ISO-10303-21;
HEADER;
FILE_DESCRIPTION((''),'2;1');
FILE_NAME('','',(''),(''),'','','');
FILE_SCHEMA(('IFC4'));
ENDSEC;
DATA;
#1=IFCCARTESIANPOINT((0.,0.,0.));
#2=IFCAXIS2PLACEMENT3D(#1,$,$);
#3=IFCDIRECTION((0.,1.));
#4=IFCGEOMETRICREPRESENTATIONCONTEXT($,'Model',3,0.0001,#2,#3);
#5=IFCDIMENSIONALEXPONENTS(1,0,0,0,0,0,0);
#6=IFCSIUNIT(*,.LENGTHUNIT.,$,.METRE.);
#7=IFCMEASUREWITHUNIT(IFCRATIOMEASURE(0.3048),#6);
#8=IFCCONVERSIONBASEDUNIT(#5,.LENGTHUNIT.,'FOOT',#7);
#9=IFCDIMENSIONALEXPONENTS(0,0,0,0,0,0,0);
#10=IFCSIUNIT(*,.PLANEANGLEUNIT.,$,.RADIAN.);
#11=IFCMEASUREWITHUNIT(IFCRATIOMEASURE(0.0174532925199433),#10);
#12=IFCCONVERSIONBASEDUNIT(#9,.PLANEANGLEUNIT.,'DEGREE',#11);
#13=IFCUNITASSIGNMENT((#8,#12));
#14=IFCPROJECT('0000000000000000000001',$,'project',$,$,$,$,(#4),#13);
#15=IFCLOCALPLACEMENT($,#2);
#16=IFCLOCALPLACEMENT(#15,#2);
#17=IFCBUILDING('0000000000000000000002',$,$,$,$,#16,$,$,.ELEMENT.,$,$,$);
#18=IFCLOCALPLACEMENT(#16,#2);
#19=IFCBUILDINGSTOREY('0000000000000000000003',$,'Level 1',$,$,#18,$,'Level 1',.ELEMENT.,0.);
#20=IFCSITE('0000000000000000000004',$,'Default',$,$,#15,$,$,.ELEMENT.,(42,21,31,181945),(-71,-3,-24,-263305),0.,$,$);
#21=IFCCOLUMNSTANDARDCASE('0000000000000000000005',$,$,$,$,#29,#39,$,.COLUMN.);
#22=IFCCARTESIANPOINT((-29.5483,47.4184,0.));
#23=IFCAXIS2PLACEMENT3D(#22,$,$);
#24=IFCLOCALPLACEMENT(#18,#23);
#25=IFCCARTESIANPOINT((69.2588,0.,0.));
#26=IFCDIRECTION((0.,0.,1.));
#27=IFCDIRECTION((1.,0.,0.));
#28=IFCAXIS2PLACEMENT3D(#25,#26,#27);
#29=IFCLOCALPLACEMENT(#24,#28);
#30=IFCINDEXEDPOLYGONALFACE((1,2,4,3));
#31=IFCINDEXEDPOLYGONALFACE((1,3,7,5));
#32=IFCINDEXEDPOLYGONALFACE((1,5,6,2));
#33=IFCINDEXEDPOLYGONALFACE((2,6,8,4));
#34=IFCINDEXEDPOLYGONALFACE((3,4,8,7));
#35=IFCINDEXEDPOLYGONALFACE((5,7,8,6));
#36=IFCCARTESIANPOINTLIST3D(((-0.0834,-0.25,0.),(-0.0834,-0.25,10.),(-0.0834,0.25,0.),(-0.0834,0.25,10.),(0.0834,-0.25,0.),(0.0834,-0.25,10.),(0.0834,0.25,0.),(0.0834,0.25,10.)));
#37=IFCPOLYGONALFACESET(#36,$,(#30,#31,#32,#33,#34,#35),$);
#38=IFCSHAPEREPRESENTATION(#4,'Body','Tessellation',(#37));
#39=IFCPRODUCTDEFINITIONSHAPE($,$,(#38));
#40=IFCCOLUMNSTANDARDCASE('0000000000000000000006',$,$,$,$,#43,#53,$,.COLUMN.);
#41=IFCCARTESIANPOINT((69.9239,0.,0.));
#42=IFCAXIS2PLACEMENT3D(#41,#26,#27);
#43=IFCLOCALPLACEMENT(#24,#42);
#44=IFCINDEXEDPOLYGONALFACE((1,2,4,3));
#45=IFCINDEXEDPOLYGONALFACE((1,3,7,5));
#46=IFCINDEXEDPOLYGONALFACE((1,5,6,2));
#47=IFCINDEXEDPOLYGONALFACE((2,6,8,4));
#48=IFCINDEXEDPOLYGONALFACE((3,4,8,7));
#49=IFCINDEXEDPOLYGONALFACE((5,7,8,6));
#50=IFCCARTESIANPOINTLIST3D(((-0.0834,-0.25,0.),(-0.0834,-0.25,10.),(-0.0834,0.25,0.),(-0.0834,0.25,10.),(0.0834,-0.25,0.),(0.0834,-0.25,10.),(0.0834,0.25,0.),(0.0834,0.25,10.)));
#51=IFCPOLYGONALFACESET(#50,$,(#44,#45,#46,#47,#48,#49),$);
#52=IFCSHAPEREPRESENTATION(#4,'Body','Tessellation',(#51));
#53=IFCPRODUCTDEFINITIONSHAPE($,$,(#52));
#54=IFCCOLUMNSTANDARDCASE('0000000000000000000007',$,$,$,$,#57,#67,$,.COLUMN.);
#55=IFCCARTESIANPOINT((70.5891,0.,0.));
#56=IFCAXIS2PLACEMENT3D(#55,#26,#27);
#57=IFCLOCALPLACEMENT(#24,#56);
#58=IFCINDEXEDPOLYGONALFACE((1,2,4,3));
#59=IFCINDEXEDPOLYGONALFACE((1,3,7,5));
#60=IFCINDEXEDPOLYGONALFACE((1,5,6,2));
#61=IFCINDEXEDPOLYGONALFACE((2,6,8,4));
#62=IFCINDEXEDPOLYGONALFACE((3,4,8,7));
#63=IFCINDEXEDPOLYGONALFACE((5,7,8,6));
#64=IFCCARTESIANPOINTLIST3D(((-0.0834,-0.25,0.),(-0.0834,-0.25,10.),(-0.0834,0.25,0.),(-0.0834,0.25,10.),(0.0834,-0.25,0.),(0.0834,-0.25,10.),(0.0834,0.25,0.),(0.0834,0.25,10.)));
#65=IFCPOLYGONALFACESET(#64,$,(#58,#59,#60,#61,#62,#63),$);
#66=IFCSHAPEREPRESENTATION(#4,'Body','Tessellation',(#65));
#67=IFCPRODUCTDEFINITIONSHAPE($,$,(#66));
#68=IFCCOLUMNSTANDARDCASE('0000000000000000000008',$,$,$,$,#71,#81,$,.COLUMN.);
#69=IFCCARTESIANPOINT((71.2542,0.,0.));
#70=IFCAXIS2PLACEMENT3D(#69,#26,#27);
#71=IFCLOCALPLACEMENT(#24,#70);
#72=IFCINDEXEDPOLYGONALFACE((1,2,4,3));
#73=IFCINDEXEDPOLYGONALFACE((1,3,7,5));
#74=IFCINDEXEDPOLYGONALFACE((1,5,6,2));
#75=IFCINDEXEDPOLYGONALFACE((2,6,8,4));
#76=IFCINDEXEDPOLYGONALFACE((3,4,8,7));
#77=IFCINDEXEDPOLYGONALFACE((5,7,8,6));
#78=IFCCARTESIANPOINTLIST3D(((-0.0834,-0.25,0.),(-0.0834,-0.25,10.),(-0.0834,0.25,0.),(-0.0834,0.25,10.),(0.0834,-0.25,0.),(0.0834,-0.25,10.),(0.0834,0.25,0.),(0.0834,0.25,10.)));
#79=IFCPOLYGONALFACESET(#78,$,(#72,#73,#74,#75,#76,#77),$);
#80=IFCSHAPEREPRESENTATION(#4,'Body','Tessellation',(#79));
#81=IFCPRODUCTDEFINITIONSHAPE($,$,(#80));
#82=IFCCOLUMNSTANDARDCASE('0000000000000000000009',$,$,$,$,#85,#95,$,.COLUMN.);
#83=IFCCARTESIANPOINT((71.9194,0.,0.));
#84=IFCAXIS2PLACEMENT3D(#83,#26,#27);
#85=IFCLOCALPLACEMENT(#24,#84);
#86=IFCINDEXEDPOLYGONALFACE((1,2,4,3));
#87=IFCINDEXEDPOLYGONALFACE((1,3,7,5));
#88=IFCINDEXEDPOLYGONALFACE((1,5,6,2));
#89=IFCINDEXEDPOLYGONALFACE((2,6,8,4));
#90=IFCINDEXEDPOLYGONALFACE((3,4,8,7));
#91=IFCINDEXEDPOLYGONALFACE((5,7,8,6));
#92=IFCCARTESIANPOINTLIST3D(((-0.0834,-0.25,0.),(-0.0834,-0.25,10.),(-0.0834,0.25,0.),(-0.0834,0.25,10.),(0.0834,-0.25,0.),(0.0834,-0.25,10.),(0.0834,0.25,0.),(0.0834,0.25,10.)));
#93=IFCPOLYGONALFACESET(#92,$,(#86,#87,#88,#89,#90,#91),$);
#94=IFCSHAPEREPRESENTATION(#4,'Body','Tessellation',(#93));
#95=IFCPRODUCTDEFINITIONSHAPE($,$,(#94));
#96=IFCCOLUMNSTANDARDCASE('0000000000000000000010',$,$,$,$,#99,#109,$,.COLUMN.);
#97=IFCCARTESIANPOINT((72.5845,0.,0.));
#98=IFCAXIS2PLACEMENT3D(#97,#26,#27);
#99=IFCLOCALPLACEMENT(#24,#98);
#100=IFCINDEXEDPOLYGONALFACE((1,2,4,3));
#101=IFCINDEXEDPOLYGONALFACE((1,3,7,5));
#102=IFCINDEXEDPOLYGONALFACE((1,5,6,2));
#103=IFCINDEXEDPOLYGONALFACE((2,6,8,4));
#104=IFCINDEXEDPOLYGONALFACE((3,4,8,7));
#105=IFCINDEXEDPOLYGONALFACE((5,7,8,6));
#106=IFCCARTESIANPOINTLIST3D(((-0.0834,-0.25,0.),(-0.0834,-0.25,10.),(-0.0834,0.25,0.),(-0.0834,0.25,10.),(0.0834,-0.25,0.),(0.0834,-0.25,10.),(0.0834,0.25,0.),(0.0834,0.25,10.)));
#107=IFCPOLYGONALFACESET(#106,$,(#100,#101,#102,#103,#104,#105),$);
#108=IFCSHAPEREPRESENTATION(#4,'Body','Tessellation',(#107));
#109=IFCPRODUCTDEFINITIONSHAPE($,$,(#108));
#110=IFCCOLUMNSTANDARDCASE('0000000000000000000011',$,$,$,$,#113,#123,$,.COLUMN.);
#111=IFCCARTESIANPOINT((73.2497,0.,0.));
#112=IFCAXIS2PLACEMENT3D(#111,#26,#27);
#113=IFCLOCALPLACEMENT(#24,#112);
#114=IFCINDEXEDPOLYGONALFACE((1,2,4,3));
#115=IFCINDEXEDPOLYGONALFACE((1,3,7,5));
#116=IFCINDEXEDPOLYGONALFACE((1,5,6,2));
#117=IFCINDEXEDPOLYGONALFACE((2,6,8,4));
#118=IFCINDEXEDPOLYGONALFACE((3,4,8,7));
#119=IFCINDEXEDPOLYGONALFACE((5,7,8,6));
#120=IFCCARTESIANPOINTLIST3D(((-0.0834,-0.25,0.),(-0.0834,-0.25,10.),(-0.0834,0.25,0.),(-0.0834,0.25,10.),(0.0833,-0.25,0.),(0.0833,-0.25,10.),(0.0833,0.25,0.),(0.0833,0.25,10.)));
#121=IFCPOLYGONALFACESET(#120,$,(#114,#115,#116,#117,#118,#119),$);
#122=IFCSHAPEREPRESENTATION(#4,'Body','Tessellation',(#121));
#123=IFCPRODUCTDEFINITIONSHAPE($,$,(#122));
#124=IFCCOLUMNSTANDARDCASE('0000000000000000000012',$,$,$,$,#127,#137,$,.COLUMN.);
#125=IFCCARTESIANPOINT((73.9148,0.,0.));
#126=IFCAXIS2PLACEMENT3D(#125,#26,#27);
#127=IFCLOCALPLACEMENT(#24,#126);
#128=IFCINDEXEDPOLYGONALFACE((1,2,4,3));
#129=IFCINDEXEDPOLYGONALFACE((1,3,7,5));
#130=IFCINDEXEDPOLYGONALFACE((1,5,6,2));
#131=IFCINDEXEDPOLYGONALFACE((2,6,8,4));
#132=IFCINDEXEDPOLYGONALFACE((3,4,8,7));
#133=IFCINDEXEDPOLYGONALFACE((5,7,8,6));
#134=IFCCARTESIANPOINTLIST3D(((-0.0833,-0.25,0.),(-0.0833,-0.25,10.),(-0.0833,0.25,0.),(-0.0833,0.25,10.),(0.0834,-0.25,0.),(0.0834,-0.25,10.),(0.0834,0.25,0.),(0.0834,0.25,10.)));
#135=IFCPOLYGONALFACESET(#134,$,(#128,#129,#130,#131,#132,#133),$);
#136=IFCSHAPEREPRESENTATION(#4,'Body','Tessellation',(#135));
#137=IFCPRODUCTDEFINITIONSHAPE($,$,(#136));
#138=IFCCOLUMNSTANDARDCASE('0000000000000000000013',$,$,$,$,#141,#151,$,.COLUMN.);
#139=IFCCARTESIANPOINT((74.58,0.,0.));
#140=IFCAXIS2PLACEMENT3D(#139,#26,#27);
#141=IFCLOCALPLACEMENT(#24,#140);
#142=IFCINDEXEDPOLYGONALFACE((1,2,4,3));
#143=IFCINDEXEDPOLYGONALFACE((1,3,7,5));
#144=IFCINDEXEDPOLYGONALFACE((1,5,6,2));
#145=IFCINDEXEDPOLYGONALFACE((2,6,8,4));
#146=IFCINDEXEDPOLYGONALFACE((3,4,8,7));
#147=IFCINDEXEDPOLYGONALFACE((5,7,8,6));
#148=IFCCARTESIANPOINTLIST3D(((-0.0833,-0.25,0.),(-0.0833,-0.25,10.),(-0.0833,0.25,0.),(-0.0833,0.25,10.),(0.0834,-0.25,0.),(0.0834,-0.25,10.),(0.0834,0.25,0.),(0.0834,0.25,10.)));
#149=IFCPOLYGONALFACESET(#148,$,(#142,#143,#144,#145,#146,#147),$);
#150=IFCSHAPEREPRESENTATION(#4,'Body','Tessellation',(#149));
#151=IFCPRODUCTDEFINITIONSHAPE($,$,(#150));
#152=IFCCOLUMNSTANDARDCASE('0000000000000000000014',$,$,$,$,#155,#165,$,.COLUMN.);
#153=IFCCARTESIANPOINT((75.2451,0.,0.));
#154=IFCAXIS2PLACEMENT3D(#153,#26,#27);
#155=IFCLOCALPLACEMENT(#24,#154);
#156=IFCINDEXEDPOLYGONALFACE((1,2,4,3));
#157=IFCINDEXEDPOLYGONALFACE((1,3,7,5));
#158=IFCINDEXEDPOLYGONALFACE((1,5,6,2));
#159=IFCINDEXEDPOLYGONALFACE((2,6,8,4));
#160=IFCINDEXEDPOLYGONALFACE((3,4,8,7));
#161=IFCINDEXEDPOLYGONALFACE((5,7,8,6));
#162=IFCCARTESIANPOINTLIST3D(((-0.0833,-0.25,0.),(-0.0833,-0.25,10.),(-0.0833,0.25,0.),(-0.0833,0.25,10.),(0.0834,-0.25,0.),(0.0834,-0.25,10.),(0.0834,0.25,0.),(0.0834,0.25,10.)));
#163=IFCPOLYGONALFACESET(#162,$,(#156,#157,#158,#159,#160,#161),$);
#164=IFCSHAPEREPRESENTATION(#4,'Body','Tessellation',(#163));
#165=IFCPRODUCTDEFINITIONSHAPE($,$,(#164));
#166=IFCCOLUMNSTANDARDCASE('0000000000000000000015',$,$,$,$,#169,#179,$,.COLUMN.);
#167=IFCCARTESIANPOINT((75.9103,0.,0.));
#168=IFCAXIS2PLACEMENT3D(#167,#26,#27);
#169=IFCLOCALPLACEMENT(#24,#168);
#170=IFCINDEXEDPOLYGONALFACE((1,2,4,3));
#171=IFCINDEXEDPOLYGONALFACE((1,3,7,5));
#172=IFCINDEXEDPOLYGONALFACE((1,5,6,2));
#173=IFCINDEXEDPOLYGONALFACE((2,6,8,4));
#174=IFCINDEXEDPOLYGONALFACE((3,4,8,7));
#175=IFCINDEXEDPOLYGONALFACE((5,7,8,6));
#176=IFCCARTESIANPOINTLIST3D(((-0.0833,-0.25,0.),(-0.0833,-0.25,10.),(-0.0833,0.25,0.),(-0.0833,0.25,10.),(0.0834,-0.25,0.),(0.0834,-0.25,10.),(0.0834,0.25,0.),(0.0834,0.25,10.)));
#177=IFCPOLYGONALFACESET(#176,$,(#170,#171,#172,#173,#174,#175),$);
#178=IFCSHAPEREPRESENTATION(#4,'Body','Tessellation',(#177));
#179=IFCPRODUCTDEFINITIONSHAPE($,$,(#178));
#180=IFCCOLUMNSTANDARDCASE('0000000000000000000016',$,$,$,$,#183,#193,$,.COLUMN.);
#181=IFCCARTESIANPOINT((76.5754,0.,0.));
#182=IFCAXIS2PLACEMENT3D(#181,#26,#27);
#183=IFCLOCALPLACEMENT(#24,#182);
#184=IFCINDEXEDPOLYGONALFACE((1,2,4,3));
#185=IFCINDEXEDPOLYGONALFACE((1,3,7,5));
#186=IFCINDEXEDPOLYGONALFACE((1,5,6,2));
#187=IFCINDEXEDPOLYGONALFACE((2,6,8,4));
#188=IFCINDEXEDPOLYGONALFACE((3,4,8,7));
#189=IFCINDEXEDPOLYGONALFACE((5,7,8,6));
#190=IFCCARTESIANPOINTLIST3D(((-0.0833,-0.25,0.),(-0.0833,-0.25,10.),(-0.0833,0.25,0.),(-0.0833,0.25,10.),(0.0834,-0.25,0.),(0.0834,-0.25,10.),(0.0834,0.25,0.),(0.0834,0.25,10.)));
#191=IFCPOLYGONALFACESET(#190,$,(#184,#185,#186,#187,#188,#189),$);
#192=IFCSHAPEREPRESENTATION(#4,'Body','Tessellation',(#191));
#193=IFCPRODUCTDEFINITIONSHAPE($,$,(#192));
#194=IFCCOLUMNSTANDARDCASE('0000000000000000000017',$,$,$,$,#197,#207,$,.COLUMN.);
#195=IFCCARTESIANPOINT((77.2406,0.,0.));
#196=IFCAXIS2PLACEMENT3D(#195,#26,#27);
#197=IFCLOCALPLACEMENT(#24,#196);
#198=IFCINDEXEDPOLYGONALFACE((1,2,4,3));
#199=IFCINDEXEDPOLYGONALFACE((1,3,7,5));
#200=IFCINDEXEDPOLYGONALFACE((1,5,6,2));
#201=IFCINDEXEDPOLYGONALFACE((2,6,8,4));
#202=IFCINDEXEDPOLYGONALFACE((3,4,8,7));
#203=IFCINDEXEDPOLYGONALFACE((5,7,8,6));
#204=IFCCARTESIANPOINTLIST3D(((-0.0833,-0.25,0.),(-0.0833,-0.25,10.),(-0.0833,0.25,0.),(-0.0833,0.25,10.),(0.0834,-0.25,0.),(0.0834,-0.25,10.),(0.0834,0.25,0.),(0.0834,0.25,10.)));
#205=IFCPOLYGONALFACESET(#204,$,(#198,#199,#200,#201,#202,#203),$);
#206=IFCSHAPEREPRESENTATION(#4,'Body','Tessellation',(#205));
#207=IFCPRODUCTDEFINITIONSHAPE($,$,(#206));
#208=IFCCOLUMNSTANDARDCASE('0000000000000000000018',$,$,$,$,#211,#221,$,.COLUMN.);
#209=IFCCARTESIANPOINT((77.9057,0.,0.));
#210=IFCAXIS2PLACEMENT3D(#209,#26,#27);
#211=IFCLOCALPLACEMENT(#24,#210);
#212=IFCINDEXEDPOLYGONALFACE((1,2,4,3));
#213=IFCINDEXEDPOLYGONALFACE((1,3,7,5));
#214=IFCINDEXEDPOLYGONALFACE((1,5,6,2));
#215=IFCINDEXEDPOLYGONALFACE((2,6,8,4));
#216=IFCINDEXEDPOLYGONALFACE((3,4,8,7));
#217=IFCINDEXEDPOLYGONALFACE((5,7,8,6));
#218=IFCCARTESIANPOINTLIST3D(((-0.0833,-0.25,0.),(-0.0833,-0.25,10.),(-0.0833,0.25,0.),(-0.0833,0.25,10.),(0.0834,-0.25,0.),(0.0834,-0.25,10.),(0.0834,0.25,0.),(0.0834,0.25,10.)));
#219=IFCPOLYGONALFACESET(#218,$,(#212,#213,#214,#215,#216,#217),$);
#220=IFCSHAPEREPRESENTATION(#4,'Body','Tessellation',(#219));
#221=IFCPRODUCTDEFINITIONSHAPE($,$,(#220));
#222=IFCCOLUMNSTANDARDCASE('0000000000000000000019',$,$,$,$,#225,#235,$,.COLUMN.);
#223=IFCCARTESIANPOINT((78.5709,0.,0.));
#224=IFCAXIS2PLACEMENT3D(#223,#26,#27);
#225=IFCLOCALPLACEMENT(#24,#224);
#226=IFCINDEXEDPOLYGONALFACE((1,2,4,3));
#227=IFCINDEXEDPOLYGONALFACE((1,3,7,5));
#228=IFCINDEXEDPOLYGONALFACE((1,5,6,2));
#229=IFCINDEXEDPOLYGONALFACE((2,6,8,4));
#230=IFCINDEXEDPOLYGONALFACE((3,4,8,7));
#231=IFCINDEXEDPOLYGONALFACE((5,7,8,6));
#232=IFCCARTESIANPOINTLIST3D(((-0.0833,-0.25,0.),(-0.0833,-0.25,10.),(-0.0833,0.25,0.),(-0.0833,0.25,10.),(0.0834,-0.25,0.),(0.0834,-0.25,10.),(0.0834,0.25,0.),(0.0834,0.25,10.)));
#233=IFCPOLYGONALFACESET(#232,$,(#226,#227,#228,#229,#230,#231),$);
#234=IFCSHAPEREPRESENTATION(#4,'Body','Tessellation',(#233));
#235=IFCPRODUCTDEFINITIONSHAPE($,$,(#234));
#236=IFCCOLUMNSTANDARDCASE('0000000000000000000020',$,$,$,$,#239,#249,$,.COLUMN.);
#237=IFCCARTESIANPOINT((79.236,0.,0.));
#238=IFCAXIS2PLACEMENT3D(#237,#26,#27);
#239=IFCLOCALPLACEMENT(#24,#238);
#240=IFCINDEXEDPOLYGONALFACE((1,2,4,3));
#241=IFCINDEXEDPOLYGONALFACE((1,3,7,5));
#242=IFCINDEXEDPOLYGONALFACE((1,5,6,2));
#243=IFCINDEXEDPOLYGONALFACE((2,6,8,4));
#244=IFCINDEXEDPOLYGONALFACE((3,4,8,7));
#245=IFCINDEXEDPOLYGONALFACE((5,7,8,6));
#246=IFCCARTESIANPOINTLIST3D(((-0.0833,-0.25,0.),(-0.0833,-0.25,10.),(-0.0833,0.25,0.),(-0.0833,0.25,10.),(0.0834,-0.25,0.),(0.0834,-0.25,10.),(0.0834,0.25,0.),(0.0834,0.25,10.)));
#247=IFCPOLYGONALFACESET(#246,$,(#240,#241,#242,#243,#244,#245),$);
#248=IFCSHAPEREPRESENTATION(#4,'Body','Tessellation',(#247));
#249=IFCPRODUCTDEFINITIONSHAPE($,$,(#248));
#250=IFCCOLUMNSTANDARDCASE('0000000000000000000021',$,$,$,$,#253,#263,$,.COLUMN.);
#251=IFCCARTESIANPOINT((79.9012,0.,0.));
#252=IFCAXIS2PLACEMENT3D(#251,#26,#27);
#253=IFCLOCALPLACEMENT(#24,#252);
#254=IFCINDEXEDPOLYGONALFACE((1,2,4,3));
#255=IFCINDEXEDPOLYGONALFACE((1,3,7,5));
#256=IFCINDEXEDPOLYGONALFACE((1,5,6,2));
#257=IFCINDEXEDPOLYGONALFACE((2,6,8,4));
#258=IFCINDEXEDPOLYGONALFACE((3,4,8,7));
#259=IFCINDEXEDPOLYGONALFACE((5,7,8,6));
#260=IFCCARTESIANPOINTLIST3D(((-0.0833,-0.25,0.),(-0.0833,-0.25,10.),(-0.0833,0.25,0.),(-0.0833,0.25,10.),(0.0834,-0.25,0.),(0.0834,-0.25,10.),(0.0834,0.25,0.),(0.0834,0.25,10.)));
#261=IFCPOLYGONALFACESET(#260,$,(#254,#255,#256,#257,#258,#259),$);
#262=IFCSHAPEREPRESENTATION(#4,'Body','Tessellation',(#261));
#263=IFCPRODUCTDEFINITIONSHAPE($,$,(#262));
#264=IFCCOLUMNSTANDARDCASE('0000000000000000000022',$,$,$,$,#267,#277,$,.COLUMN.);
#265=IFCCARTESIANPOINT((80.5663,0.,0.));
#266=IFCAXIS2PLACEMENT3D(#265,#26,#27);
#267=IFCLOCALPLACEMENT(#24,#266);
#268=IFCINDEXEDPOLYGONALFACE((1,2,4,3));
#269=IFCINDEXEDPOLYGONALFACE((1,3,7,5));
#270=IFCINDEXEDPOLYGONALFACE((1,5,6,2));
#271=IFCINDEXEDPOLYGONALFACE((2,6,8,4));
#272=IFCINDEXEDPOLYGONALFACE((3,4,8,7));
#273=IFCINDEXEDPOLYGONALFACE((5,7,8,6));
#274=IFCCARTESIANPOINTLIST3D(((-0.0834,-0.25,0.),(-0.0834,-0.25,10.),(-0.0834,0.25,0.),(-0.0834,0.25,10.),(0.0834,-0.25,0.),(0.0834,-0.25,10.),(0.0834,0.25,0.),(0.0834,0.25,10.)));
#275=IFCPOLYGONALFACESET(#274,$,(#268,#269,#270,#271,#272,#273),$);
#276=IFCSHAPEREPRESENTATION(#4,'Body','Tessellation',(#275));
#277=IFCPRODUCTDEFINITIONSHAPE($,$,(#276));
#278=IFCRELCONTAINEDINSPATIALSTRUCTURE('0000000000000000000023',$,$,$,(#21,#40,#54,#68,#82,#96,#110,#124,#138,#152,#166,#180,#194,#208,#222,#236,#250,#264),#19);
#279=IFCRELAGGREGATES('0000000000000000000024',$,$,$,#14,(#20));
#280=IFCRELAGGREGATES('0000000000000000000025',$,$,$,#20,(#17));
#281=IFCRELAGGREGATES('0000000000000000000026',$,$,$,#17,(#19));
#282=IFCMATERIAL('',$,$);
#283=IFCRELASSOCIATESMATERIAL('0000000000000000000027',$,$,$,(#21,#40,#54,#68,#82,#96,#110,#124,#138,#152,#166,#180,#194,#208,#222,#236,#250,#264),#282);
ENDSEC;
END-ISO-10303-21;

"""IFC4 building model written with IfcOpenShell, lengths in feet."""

from ifc_helpers import new_model, entity, si_unit, converted_unit, direction, frame, origin, place, context, project, spatial, rectangle, extrude, material, element, save


model = new_model("IFC4")

# Units and contexts
model_context = context("Model", 3, precision=0.0001, world=origin(), true_north=direction((0.0, 1.0)))
ifc_project = project(units=[converted_unit("LENGTHUNIT", "FOOT", entity("IfcRatioMeasure", 0.3048), si_unit("LENGTHUNIT", "METRE"), dimensions=[1, 0, 0, 0, 0, 0, 0]), converted_unit("PLANEANGLEUNIT", "DEGREE", entity("IfcRatioMeasure", 0.0174532925199433), si_unit("PLANEANGLEUNIT", "RADIAN"), dimensions=[0, 0, 0, 0, 0, 0, 0])], contexts=[model_context])

# Site, building, storey
site_placement = place(None, origin())
site = spatial("IfcSite", under=ifc_project, at=site_placement, Name="Default", CompositionType="ELEMENT", RefLatitude=(42, 21, 31, 181945), RefLongitude=(-71, -3, -24, -263305), RefElevation=0.0)
building_placement = place(site_placement, origin())
building = spatial("IfcBuilding", under=site, at=building_placement, CompositionType="ELEMENT")
storey_placement = place(building_placement, origin())
storey = spatial("IfcBuildingStorey", under=building, at=storey_placement, Name="Level 1", LongName="Level 1", CompositionType="ELEMENT", Elevation=0.0)

# Columns
ifc_material_1 = material(Name="")
placement = place(storey_placement, frame((-29.5483, 47.4184, 0.0)))
for number, where, z_axis, x_axis in (
    (1, (69.2588, 0.0, 0.0), (0.0, 0.0, 1.0), (1.0, 0.0, 0.0)),
    (2, (69.9239, 0.0, 0.0), (0.0, 0.0, 1.0), (1.0, 0.0, 0.0)),
    (3, (70.5891, 0.0, 0.0), (0.0, 0.0, 1.0), (1.0, 0.0, 0.0)),
    (4, (71.2542, 0.0, 0.0), (0.0, 0.0, 1.0), (1.0, 0.0, 0.0)),
    (5, (71.9194, 0.0, 0.0), (0.0, 0.0, 1.0), (1.0, 0.0, 0.0)),
    (6, (72.5845, 0.0, 0.0), (0.0, 0.0, 1.0), (1.0, 0.0, 0.0)),
    (7, (73.2497, 0.0, 0.0), (0.0, 0.0, 1.0), (1.0, 0.0, 0.0)),
    (8, (73.9148, 0.0, 0.0), (0.0, 0.0, 1.0), (1.0, 0.0, 0.0)),
    (9, (74.58, 0.0, 0.0), (0.0, 0.0, 1.0), (1.0, 0.0, 0.0)),
    (10, (75.2451, 0.0, 0.0), (0.0, 0.0, 1.0), (1.0, 0.0, 0.0)),
    (11, (75.9103, 0.0, 0.0), (0.0, 0.0, 1.0), (1.0, 0.0, 0.0)),
    (12, (76.5754, 0.0, 0.0), (0.0, 0.0, 1.0), (1.0, 0.0, 0.0)),
    (13, (77.2406, 0.0, 0.0), (0.0, 0.0, 1.0), (1.0, 0.0, 0.0)),
    (14, (77.9057, 0.0, 0.0), (0.0, 0.0, 1.0), (1.0, 0.0, 0.0)),
    (15, (78.5709, 0.0, 0.0), (0.0, 0.0, 1.0), (1.0, 0.0, 0.0)),
    (16, (79.236, 0.0, 0.0), (0.0, 0.0, 1.0), (1.0, 0.0, 0.0)),
    (17, (79.9012, 0.0, 0.0), (0.0, 0.0, 1.0), (1.0, 0.0, 0.0)),
    (18, (80.5663, 0.0, 0.0), (0.0, 0.0, 1.0), (1.0, 0.0, 0.0)),
):
    element("IfcColumnStandardCase", number, at=place(placement, frame(where, z_axis=z_axis, x_axis=x_axis)), inside=storey, material=ifc_material_1, PredefinedType="COLUMN", context=model_context, shape_type="SweptSolid", body=[
        extrude(rectangle(XDim=0.1667, YDim=0.5), origin(), (0.0, 0.0, 1.0), 10.0),
    ])

save(model, "model.ifc")
